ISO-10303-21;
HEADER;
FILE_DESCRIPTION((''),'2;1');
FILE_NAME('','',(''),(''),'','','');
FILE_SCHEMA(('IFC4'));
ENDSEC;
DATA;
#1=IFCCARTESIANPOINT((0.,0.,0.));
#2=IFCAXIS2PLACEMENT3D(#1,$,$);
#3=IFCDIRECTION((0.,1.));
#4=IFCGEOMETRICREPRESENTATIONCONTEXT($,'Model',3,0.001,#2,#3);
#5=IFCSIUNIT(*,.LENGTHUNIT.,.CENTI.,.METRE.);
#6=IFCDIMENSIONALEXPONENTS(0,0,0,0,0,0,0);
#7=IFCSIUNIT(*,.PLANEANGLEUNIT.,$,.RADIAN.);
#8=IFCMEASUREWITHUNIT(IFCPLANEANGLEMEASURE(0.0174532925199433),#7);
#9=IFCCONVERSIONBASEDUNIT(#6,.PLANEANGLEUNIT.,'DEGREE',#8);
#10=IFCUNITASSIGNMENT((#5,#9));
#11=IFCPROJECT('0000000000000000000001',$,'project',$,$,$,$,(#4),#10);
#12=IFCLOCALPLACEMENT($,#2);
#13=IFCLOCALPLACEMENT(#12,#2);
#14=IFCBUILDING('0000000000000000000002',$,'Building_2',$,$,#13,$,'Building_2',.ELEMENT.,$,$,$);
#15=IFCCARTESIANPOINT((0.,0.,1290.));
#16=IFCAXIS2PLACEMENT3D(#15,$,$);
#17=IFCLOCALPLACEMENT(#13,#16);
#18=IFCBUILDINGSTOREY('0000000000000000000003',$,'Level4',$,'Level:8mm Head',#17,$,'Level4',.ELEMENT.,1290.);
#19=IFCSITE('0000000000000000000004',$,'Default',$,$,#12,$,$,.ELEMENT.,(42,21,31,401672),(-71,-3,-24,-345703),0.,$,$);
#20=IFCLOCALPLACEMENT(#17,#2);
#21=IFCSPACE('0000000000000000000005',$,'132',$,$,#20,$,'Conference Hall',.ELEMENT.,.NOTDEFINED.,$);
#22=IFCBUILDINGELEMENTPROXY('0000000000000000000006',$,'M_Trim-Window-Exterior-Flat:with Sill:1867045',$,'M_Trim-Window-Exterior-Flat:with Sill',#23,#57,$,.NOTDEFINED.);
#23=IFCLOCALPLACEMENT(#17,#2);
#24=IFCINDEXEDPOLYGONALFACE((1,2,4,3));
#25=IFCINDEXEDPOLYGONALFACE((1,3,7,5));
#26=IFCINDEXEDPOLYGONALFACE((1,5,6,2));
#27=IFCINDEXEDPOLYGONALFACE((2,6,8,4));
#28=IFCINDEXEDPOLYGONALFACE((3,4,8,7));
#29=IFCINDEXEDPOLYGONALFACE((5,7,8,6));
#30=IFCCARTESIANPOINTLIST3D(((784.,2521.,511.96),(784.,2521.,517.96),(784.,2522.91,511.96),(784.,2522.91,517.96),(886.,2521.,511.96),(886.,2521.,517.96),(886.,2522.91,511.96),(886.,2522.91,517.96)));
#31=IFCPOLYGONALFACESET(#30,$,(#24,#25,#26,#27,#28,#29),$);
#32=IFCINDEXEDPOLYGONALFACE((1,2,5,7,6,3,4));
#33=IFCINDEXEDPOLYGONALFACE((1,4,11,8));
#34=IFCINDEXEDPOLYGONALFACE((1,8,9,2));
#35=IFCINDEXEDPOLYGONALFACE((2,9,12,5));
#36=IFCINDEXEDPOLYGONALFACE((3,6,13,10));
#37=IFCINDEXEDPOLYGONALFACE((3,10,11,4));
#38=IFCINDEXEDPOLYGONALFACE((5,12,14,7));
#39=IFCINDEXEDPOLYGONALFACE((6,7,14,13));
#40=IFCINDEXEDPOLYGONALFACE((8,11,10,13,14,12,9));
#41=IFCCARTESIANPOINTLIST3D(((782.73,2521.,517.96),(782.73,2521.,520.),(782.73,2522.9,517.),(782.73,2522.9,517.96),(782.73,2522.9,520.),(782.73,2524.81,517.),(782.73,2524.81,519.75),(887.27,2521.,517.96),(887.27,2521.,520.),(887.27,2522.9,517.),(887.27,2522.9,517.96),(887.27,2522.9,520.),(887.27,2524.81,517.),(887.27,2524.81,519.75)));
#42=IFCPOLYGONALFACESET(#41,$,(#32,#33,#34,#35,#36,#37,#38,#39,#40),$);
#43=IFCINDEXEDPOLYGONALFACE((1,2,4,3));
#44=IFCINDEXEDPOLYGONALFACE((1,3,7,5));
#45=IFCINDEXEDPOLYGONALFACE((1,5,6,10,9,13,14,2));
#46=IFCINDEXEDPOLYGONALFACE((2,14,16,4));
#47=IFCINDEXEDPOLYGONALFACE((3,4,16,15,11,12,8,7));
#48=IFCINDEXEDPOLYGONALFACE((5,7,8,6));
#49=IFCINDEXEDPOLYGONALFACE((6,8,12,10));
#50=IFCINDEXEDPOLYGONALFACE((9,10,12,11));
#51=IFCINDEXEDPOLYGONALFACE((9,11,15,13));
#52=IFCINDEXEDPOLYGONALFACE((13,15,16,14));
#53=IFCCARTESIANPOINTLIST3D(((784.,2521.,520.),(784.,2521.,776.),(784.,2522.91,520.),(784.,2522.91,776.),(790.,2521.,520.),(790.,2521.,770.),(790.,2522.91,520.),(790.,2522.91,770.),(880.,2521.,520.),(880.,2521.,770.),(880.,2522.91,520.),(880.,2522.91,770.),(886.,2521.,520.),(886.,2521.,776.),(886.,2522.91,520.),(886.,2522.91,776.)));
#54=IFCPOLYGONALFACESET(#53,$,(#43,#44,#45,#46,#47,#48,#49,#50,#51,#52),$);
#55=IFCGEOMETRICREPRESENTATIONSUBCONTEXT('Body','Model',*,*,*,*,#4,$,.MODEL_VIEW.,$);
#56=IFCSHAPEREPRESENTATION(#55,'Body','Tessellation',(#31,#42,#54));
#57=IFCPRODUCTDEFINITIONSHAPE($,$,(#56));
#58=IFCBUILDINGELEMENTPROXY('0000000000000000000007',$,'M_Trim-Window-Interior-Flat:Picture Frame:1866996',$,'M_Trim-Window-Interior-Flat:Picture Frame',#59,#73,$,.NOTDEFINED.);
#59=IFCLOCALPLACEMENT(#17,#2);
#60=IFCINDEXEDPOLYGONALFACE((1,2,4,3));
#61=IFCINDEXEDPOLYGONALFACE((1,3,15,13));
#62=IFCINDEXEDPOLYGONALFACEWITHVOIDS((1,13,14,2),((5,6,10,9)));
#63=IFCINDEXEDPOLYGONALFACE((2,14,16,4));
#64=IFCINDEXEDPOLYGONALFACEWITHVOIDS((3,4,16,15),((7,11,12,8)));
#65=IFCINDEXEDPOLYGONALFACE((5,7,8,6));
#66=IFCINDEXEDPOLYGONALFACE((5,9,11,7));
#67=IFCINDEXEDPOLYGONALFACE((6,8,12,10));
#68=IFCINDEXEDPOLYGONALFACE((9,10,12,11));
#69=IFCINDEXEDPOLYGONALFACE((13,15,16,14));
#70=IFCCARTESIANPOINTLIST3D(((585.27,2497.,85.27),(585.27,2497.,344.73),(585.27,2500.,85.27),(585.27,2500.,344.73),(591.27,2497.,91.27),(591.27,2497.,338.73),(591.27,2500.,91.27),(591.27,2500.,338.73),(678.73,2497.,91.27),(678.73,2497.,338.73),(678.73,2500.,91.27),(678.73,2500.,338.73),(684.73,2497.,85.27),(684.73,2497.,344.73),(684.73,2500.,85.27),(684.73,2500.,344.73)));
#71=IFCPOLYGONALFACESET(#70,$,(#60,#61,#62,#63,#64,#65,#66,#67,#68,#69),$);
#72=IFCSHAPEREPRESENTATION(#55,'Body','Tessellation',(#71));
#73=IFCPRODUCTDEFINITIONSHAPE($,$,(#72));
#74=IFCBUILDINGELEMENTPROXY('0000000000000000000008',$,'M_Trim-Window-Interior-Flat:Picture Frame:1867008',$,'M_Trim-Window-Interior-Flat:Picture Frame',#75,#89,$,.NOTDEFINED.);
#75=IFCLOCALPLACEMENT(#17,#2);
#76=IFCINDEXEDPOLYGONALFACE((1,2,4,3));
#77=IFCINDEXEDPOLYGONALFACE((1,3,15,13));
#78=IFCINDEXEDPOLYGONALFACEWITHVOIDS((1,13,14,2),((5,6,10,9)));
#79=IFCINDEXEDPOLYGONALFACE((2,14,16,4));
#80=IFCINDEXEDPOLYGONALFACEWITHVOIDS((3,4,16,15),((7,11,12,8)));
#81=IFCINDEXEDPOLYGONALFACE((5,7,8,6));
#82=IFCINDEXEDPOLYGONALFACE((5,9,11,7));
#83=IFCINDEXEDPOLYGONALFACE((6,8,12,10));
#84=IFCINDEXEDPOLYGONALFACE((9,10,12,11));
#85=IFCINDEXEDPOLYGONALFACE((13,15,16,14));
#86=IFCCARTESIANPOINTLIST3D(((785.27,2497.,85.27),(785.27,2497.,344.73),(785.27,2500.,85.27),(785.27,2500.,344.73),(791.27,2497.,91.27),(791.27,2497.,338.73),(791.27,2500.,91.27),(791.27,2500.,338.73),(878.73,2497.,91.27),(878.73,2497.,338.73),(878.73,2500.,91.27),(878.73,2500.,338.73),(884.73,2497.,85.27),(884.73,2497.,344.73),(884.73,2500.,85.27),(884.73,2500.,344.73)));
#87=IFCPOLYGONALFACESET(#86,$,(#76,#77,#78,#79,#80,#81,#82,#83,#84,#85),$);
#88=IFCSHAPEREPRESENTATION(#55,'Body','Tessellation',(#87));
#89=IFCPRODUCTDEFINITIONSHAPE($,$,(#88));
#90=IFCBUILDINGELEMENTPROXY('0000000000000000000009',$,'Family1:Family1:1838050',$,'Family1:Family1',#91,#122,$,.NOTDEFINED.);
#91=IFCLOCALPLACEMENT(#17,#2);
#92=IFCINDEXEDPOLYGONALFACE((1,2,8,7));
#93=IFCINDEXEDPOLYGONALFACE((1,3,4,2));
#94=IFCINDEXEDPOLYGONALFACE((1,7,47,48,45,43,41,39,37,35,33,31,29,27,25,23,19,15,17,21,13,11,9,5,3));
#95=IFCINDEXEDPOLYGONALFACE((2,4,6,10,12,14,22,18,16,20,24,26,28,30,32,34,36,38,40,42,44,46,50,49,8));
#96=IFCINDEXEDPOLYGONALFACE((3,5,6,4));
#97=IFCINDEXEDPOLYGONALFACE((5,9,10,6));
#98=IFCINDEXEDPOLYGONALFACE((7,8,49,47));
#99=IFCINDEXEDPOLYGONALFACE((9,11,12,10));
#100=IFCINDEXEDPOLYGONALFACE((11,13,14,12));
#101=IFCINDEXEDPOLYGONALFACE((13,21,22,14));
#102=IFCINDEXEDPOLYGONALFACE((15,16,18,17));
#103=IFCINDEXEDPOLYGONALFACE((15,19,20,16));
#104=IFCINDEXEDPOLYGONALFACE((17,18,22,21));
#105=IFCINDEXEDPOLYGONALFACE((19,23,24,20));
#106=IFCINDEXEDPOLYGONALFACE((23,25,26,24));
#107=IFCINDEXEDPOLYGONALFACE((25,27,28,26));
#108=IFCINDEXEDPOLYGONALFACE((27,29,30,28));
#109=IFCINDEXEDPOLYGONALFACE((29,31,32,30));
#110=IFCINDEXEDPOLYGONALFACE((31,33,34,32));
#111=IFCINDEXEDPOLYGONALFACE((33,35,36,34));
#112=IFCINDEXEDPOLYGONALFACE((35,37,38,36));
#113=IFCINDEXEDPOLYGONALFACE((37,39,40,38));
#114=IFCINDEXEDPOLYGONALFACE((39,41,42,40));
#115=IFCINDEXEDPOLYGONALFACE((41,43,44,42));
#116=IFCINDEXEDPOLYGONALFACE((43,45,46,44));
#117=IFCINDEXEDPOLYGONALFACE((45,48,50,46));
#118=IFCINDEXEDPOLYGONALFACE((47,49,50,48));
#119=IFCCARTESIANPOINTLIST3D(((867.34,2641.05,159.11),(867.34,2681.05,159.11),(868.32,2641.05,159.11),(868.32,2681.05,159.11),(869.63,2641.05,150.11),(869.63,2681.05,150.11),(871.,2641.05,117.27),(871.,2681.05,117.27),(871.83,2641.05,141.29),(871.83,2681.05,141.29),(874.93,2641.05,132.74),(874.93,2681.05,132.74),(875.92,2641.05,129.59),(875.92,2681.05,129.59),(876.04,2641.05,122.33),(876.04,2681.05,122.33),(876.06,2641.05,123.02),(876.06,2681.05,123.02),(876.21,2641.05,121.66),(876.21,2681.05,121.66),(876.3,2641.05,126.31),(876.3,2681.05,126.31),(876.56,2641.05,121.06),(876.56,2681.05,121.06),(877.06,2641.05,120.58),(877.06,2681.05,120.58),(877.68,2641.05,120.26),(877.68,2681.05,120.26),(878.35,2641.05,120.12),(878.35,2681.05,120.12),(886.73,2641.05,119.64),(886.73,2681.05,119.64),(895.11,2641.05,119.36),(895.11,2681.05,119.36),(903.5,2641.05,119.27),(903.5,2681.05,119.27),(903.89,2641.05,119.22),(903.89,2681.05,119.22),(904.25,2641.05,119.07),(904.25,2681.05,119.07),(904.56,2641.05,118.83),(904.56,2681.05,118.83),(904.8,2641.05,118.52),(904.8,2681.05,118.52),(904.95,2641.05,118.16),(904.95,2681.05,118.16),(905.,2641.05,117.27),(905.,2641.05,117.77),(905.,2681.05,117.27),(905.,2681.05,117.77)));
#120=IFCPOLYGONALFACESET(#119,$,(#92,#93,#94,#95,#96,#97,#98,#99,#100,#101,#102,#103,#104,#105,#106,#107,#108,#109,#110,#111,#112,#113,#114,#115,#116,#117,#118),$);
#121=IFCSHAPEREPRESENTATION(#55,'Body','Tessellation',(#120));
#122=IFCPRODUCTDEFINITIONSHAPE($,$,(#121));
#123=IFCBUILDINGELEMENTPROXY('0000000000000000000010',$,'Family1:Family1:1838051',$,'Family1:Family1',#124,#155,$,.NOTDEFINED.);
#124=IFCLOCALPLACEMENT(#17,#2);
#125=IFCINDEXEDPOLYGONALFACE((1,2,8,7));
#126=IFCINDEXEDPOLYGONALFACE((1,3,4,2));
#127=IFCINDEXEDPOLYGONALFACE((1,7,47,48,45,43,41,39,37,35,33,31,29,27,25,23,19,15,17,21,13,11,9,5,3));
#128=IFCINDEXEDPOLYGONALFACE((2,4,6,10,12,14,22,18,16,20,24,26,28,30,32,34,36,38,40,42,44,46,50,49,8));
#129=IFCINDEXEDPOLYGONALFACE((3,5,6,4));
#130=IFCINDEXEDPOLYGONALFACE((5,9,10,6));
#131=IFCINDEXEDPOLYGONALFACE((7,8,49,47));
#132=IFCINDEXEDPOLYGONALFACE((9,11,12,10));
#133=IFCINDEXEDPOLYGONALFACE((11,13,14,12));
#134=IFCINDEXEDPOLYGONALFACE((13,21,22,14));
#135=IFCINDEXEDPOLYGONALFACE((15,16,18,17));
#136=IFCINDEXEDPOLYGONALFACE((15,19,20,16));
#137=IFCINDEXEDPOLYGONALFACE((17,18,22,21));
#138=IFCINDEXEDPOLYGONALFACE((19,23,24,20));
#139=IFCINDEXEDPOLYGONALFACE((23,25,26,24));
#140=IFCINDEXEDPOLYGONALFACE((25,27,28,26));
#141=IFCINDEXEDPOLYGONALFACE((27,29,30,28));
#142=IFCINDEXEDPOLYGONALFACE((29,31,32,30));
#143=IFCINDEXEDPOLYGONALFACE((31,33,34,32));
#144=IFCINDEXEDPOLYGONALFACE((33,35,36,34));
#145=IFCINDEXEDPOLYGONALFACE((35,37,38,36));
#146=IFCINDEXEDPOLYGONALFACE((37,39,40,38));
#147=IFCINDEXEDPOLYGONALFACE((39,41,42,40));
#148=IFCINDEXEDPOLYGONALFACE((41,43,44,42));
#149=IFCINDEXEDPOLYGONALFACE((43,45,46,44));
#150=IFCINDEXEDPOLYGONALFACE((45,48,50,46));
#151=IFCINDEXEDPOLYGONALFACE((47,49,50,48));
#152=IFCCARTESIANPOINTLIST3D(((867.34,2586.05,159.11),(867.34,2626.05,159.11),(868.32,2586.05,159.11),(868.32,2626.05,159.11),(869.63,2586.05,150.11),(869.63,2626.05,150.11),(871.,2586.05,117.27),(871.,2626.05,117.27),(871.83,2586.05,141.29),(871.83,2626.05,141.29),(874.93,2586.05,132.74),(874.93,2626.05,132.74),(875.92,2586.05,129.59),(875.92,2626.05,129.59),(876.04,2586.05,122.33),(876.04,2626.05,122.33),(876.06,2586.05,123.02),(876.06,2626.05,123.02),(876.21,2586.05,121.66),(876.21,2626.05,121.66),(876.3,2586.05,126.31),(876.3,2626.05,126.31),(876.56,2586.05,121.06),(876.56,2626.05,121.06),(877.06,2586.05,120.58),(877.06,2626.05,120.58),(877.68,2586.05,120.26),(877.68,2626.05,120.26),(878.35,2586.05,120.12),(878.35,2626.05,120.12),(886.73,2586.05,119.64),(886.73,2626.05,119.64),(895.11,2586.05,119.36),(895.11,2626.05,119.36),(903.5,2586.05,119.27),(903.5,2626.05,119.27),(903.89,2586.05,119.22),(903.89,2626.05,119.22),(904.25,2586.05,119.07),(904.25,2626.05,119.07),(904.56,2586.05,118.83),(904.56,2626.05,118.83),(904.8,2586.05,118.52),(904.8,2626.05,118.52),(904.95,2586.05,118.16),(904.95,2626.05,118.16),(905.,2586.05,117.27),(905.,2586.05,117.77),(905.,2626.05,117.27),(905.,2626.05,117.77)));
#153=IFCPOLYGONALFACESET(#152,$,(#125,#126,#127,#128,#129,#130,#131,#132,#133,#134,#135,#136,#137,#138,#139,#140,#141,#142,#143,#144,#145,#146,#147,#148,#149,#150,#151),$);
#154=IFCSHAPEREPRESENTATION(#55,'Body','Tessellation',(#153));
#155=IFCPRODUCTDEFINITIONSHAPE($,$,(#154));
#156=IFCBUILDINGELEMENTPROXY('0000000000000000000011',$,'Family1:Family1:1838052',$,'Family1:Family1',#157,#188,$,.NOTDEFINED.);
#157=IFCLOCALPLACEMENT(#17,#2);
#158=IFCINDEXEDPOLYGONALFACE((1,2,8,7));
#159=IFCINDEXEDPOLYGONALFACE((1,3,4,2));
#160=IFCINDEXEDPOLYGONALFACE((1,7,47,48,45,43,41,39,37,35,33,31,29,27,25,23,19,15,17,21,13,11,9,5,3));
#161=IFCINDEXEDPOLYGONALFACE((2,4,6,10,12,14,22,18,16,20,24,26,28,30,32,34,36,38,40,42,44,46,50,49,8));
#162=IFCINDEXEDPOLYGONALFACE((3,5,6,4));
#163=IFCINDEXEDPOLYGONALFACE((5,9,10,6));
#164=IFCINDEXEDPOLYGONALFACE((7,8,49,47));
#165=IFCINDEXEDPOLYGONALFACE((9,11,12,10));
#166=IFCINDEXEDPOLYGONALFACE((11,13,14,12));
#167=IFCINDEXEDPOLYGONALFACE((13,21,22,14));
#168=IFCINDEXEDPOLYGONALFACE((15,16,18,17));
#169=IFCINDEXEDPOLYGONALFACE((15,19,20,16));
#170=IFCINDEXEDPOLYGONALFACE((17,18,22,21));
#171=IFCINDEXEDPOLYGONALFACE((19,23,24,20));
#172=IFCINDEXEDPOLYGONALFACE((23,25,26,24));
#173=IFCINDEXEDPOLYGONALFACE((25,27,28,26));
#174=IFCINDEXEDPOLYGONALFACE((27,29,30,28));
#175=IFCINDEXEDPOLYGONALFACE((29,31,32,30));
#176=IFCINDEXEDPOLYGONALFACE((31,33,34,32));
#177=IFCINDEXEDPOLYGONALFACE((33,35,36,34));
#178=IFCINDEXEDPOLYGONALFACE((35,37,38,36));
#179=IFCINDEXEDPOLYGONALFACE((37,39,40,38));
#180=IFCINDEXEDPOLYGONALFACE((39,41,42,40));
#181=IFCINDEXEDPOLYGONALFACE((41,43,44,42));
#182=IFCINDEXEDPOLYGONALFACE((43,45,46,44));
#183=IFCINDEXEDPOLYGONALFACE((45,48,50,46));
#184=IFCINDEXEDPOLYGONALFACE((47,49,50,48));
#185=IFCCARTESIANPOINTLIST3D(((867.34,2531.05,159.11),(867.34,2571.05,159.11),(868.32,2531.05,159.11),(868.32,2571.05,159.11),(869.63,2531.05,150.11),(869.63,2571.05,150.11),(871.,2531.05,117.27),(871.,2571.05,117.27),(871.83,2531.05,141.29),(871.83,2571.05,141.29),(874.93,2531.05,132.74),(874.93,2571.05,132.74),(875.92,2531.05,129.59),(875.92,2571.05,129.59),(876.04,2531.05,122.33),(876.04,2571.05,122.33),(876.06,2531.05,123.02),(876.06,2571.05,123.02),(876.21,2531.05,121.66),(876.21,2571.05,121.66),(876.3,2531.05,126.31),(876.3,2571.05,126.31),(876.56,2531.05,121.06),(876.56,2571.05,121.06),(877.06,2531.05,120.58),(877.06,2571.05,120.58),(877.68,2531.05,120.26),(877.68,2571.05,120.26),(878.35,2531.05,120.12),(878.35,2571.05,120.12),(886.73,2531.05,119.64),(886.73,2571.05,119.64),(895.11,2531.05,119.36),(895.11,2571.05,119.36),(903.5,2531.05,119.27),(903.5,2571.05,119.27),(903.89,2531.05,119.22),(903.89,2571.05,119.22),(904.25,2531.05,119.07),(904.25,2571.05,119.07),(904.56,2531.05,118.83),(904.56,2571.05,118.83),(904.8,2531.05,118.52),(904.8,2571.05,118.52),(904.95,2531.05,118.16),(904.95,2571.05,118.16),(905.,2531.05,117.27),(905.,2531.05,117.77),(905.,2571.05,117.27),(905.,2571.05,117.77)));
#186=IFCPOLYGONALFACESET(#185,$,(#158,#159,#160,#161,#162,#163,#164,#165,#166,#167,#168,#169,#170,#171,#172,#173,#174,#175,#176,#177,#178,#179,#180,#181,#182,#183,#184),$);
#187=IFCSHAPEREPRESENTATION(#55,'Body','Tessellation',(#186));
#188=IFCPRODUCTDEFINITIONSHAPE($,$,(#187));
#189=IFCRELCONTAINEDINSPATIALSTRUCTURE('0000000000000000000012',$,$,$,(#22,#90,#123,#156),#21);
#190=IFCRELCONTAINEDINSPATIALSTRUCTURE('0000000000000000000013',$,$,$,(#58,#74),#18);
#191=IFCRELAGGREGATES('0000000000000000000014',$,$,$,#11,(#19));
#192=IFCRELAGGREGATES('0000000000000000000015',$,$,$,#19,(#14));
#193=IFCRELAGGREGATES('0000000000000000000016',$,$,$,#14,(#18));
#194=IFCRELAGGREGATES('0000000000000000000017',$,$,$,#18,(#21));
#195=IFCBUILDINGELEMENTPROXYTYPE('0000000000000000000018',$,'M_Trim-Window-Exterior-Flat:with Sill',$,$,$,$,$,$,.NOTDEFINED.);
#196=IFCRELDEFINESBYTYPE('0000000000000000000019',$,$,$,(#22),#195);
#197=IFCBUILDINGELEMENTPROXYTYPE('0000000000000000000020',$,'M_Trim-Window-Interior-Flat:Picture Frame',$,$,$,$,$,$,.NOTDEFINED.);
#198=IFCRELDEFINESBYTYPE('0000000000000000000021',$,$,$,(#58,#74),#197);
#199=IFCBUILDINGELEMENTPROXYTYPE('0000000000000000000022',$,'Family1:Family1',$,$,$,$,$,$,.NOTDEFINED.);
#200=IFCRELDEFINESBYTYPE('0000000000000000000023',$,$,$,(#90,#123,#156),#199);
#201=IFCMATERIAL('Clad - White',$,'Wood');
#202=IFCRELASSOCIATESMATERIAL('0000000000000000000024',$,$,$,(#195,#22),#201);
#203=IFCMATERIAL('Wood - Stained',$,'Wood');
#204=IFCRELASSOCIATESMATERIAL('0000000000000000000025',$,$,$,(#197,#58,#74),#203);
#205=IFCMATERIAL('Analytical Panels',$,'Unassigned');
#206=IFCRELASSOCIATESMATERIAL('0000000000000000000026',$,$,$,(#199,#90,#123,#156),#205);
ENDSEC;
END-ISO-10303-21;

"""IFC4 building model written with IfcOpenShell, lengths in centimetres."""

from ifc_helpers import new_model, entity, si_unit, converted_unit, direction, frame, origin, place, context, subcontext, project, spatial, line, arc, indexed_curve, outline, extrude, source, transform, mapped, material, type_object, type_shapes, element, save


model = new_model("IFC4")

# Units and contexts
model_context = context("Model", 3, precision=0.001, world=origin(), true_north=direction((0.0, 1.0)))
body_context = subcontext(model_context, "Body", "Model", "MODEL_VIEW")
ifc_project = project(units=[si_unit("LENGTHUNIT", "METRE", prefix="CENTI"), converted_unit("PLANEANGLEUNIT", "DEGREE", entity("IfcPlaneAngleMeasure", 0.0174532925199433), si_unit("PLANEANGLEUNIT", "RADIAN"), dimensions=[0, 0, 0, 0, 0, 0, 0])], contexts=[model_context])

# Site, building, storey
site_placement = place(None, origin())
site = spatial("IfcSite", under=ifc_project, at=site_placement, Name="Default", CompositionType="ELEMENT", RefLatitude=(42, 21, 31, 401672), RefLongitude=(-71, -3, -24, -345703), RefElevation=0.0)
building_placement = place(site_placement, origin())
building = spatial("IfcBuilding", under=site, at=building_placement, Name="Building_2", LongName="Building_2", CompositionType="ELEMENT")
storey_placement = place(building_placement, frame((0.0, 0.0, 1290.0)))
storey = spatial("IfcBuildingStorey", under=building, at=storey_placement, Name="Level4", ObjectType="Level:8mm Head", LongName="Level4", CompositionType="ELEMENT", Elevation=1290.0)

# Shared definitions
ifc_material_1 = material(Name="Clad - White", Category="Wood")
ifc_material_2 = material(Name="Wood - Stained", Category="Wood")

# Shared definitions
space_1_placement = place(storey_placement, origin())
space_1 = spatial("IfcSpace", under=storey, at=space_1_placement, Name="132", LongName="Conference Hall", CompositionType="ELEMENT", PredefinedType="NOTDEFINED")

# Building element proxies
building_element_proxy_type_1 = type_object("IfcBuildingElementProxyType", Name="M_Trim-Window-Exterior-Flat:with Sill", PredefinedType="NOTDEFINED", material=ifc_material_1)
shared_shape_1 = source(origin(), body_context, "Body", "SweptSolid", [
    extrude(outline(indexed_curve([(-51.0, -3.0), (51.0, -3.0), (51.0, 3.0), (-51.0, 3.0), (-51.0, -3.0)], self_intersect=False)), frame((0.0, -255.04, 0.0), z_axis=(0.0, 0.0, 1.0), x_axis=(-1.0, 0.0, 0.0)), (0.0, 0.0, 1.0), 1.91),
    extrude(outline(indexed_curve([(-1.9, -1.52), (0.0, -1.52), (0.0, -0.57), (1.9, -0.57), (1.9, 1.48), (0.0, 1.48), (-1.9, 1.23), (-1.9, -1.52)], self_intersect=False)), frame((-52.27, -251.48, 1.9), z_axis=(1.0, 0.0, 0.0), x_axis=(0.0, 0.0, -1.0)), (0.0, 0.0, 1.0), 104.54),
    extrude(outline(indexed_curve([(-129.5, -51.0), (126.5, -51.0), (126.5, -45.0), (-123.5, -45.0), (-123.5, 45.0), (126.5, 45.0), (126.5, 51.0), (-129.5, 51.0), (-129.5, -51.0)], self_intersect=False)), frame((0.0, -123.5, 0.0), z_axis=(0.0, 0.0, 1.0), x_axis=(0.0, -1.0, 0.0)), (0.0, 0.0, 1.0), 1.91),
])
type_shapes(building_element_proxy_type_1, [shared_shape_1])
for number, where, z_axis, x_axis, name in (
    (1, (835.0, 2521.0, 770.0), (0.0, 1.0, 0.0), (-1.0, 0.0, 0.0), "M_Trim-Window-Exterior-Flat:with Sill:1867045"),
):
    element("IfcBuildingElementProxy", number, at=place(space_1_placement, frame(where, z_axis=z_axis, x_axis=x_axis)), inside=space_1, type_object=building_element_proxy_type_1, material=ifc_material_1, Name=name, ObjectType="M_Trim-Window-Exterior-Flat:with Sill", PredefinedType="NOTDEFINED", context=body_context, shape_type="MappedRepresentation", body=[
        mapped(shared_shape_1, transform((0.0, 0.0, 0.0), scale=1.0)),
    ])
building_element_proxy_type_2 = type_object("IfcBuildingElementProxyType", Name="M_Trim-Window-Interior-Flat:Picture Frame", PredefinedType="NOTDEFINED", material=ifc_material_2)
shared_shape_2 = source(origin(), body_context, "Body", "SweptSolid", [
    extrude(outline(indexed_curve([(-49.73, -129.73), (49.73, -129.73), (49.73, 129.73), (-49.73, 129.73), (-49.73, -129.73)], self_intersect=False), holes=[indexed_curve([(-43.73, -123.73), (-43.73, 123.73), (43.73, 123.73), (43.73, -123.73), (-43.73, -123.73)], self_intersect=False)]), frame((0.0, -125.0, 0.0), z_axis=(0.0, 0.0, 1.0), x_axis=(-1.0, 0.0, 0.0)), (0.0, 0.0, 1.0), 3.0),
])
type_shapes(building_element_proxy_type_2, [shared_shape_2])
for number, where, z_axis, x_axis, name in (
    (2, (635.0, 2500.0, 340.0), (0.0, -1.0, 0.0), (1.0, 0.0, 0.0), "M_Trim-Window-Interior-Flat:Picture Frame:1866996"),
    (3, (835.0, 2500.0, 340.0), (0.0, -1.0, 0.0), (1.0, 0.0, 0.0), "M_Trim-Window-Interior-Flat:Picture Frame:1867008"),
):
    element("IfcBuildingElementProxy", number, at=place(storey_placement, frame(where, z_axis=z_axis, x_axis=x_axis)), inside=storey, type_object=building_element_proxy_type_2, material=ifc_material_2, Name=name, ObjectType="M_Trim-Window-Interior-Flat:Picture Frame", PredefinedType="NOTDEFINED", context=body_context, shape_type="MappedRepresentation", body=[
        mapped(shared_shape_2, transform((0.0, 0.0, 0.0), scale=1.0)),
    ])
ifc_material_3 = material(Name="Analytical Panels", Category="Unassigned")
building_element_proxy_type_3 = type_object("IfcBuildingElementProxyType", Name="Family1:Family1", PredefinedType="NOTDEFINED", material=ifc_material_3)
shared_shape_3 = source(origin(), body_context, "Body", "SweptSolid", [
    extrude(outline(indexed_curve([(-11.13, -13.3), (30.87, -13.3), (30.78, -12.32), (17.19, -11.21), (3.93, -8.04), (-0.94, -7.2), (-5.84, -7.76), (-7.84, -7.43), (-8.94, -5.73), (-10.68, 6.74), (-11.98, 19.25), (-12.51, 20.27), (-13.6, 20.61), (-14.09, 20.57)], segments=[line(1, 2, 3), arc(3, 4, 5), arc(5, 6, 7), arc(7, 8, 9), arc(9, 10, 11), arc(11, 12, 13), line(13, 14, 1)], self_intersect=False)), frame((-20.0, 6.72, 12.25), z_axis=(1.0, 0.0, 0.0), x_axis=(0.0, 0.087156, 0.996195)), (0.0, 0.0, 1.0), 40.0),
])
type_shapes(building_element_proxy_type_3, [shared_shape_3])
for number, where, z_axis, x_axis, name in (
    (4, (890.0, 2661.05, 117.27), (0.0, 0.0, 1.0), (0.0, 1.0, 0.0), "Family1:Family1:1838050"),
    (5, (890.0, 2606.05, 117.27), (0.0, 0.0, 1.0), (0.0, 1.0, 0.0), "Family1:Family1:1838051"),
    (6, (890.0, 2551.05, 117.27), (0.0, 0.0, 1.0), (0.0, 1.0, 0.0), "Family1:Family1:1838052"),
):
    element("IfcBuildingElementProxy", number, at=place(space_1_placement, frame(where, z_axis=z_axis, x_axis=x_axis)), inside=space_1, type_object=building_element_proxy_type_3, material=ifc_material_3, Name=name, ObjectType="Family1:Family1", PredefinedType="NOTDEFINED", context=body_context, shape_type="MappedRepresentation", body=[
        mapped(shared_shape_3, transform((0.0, 0.0, 0.0), scale=1.0)),
    ])

save(model, "model.ifc")
